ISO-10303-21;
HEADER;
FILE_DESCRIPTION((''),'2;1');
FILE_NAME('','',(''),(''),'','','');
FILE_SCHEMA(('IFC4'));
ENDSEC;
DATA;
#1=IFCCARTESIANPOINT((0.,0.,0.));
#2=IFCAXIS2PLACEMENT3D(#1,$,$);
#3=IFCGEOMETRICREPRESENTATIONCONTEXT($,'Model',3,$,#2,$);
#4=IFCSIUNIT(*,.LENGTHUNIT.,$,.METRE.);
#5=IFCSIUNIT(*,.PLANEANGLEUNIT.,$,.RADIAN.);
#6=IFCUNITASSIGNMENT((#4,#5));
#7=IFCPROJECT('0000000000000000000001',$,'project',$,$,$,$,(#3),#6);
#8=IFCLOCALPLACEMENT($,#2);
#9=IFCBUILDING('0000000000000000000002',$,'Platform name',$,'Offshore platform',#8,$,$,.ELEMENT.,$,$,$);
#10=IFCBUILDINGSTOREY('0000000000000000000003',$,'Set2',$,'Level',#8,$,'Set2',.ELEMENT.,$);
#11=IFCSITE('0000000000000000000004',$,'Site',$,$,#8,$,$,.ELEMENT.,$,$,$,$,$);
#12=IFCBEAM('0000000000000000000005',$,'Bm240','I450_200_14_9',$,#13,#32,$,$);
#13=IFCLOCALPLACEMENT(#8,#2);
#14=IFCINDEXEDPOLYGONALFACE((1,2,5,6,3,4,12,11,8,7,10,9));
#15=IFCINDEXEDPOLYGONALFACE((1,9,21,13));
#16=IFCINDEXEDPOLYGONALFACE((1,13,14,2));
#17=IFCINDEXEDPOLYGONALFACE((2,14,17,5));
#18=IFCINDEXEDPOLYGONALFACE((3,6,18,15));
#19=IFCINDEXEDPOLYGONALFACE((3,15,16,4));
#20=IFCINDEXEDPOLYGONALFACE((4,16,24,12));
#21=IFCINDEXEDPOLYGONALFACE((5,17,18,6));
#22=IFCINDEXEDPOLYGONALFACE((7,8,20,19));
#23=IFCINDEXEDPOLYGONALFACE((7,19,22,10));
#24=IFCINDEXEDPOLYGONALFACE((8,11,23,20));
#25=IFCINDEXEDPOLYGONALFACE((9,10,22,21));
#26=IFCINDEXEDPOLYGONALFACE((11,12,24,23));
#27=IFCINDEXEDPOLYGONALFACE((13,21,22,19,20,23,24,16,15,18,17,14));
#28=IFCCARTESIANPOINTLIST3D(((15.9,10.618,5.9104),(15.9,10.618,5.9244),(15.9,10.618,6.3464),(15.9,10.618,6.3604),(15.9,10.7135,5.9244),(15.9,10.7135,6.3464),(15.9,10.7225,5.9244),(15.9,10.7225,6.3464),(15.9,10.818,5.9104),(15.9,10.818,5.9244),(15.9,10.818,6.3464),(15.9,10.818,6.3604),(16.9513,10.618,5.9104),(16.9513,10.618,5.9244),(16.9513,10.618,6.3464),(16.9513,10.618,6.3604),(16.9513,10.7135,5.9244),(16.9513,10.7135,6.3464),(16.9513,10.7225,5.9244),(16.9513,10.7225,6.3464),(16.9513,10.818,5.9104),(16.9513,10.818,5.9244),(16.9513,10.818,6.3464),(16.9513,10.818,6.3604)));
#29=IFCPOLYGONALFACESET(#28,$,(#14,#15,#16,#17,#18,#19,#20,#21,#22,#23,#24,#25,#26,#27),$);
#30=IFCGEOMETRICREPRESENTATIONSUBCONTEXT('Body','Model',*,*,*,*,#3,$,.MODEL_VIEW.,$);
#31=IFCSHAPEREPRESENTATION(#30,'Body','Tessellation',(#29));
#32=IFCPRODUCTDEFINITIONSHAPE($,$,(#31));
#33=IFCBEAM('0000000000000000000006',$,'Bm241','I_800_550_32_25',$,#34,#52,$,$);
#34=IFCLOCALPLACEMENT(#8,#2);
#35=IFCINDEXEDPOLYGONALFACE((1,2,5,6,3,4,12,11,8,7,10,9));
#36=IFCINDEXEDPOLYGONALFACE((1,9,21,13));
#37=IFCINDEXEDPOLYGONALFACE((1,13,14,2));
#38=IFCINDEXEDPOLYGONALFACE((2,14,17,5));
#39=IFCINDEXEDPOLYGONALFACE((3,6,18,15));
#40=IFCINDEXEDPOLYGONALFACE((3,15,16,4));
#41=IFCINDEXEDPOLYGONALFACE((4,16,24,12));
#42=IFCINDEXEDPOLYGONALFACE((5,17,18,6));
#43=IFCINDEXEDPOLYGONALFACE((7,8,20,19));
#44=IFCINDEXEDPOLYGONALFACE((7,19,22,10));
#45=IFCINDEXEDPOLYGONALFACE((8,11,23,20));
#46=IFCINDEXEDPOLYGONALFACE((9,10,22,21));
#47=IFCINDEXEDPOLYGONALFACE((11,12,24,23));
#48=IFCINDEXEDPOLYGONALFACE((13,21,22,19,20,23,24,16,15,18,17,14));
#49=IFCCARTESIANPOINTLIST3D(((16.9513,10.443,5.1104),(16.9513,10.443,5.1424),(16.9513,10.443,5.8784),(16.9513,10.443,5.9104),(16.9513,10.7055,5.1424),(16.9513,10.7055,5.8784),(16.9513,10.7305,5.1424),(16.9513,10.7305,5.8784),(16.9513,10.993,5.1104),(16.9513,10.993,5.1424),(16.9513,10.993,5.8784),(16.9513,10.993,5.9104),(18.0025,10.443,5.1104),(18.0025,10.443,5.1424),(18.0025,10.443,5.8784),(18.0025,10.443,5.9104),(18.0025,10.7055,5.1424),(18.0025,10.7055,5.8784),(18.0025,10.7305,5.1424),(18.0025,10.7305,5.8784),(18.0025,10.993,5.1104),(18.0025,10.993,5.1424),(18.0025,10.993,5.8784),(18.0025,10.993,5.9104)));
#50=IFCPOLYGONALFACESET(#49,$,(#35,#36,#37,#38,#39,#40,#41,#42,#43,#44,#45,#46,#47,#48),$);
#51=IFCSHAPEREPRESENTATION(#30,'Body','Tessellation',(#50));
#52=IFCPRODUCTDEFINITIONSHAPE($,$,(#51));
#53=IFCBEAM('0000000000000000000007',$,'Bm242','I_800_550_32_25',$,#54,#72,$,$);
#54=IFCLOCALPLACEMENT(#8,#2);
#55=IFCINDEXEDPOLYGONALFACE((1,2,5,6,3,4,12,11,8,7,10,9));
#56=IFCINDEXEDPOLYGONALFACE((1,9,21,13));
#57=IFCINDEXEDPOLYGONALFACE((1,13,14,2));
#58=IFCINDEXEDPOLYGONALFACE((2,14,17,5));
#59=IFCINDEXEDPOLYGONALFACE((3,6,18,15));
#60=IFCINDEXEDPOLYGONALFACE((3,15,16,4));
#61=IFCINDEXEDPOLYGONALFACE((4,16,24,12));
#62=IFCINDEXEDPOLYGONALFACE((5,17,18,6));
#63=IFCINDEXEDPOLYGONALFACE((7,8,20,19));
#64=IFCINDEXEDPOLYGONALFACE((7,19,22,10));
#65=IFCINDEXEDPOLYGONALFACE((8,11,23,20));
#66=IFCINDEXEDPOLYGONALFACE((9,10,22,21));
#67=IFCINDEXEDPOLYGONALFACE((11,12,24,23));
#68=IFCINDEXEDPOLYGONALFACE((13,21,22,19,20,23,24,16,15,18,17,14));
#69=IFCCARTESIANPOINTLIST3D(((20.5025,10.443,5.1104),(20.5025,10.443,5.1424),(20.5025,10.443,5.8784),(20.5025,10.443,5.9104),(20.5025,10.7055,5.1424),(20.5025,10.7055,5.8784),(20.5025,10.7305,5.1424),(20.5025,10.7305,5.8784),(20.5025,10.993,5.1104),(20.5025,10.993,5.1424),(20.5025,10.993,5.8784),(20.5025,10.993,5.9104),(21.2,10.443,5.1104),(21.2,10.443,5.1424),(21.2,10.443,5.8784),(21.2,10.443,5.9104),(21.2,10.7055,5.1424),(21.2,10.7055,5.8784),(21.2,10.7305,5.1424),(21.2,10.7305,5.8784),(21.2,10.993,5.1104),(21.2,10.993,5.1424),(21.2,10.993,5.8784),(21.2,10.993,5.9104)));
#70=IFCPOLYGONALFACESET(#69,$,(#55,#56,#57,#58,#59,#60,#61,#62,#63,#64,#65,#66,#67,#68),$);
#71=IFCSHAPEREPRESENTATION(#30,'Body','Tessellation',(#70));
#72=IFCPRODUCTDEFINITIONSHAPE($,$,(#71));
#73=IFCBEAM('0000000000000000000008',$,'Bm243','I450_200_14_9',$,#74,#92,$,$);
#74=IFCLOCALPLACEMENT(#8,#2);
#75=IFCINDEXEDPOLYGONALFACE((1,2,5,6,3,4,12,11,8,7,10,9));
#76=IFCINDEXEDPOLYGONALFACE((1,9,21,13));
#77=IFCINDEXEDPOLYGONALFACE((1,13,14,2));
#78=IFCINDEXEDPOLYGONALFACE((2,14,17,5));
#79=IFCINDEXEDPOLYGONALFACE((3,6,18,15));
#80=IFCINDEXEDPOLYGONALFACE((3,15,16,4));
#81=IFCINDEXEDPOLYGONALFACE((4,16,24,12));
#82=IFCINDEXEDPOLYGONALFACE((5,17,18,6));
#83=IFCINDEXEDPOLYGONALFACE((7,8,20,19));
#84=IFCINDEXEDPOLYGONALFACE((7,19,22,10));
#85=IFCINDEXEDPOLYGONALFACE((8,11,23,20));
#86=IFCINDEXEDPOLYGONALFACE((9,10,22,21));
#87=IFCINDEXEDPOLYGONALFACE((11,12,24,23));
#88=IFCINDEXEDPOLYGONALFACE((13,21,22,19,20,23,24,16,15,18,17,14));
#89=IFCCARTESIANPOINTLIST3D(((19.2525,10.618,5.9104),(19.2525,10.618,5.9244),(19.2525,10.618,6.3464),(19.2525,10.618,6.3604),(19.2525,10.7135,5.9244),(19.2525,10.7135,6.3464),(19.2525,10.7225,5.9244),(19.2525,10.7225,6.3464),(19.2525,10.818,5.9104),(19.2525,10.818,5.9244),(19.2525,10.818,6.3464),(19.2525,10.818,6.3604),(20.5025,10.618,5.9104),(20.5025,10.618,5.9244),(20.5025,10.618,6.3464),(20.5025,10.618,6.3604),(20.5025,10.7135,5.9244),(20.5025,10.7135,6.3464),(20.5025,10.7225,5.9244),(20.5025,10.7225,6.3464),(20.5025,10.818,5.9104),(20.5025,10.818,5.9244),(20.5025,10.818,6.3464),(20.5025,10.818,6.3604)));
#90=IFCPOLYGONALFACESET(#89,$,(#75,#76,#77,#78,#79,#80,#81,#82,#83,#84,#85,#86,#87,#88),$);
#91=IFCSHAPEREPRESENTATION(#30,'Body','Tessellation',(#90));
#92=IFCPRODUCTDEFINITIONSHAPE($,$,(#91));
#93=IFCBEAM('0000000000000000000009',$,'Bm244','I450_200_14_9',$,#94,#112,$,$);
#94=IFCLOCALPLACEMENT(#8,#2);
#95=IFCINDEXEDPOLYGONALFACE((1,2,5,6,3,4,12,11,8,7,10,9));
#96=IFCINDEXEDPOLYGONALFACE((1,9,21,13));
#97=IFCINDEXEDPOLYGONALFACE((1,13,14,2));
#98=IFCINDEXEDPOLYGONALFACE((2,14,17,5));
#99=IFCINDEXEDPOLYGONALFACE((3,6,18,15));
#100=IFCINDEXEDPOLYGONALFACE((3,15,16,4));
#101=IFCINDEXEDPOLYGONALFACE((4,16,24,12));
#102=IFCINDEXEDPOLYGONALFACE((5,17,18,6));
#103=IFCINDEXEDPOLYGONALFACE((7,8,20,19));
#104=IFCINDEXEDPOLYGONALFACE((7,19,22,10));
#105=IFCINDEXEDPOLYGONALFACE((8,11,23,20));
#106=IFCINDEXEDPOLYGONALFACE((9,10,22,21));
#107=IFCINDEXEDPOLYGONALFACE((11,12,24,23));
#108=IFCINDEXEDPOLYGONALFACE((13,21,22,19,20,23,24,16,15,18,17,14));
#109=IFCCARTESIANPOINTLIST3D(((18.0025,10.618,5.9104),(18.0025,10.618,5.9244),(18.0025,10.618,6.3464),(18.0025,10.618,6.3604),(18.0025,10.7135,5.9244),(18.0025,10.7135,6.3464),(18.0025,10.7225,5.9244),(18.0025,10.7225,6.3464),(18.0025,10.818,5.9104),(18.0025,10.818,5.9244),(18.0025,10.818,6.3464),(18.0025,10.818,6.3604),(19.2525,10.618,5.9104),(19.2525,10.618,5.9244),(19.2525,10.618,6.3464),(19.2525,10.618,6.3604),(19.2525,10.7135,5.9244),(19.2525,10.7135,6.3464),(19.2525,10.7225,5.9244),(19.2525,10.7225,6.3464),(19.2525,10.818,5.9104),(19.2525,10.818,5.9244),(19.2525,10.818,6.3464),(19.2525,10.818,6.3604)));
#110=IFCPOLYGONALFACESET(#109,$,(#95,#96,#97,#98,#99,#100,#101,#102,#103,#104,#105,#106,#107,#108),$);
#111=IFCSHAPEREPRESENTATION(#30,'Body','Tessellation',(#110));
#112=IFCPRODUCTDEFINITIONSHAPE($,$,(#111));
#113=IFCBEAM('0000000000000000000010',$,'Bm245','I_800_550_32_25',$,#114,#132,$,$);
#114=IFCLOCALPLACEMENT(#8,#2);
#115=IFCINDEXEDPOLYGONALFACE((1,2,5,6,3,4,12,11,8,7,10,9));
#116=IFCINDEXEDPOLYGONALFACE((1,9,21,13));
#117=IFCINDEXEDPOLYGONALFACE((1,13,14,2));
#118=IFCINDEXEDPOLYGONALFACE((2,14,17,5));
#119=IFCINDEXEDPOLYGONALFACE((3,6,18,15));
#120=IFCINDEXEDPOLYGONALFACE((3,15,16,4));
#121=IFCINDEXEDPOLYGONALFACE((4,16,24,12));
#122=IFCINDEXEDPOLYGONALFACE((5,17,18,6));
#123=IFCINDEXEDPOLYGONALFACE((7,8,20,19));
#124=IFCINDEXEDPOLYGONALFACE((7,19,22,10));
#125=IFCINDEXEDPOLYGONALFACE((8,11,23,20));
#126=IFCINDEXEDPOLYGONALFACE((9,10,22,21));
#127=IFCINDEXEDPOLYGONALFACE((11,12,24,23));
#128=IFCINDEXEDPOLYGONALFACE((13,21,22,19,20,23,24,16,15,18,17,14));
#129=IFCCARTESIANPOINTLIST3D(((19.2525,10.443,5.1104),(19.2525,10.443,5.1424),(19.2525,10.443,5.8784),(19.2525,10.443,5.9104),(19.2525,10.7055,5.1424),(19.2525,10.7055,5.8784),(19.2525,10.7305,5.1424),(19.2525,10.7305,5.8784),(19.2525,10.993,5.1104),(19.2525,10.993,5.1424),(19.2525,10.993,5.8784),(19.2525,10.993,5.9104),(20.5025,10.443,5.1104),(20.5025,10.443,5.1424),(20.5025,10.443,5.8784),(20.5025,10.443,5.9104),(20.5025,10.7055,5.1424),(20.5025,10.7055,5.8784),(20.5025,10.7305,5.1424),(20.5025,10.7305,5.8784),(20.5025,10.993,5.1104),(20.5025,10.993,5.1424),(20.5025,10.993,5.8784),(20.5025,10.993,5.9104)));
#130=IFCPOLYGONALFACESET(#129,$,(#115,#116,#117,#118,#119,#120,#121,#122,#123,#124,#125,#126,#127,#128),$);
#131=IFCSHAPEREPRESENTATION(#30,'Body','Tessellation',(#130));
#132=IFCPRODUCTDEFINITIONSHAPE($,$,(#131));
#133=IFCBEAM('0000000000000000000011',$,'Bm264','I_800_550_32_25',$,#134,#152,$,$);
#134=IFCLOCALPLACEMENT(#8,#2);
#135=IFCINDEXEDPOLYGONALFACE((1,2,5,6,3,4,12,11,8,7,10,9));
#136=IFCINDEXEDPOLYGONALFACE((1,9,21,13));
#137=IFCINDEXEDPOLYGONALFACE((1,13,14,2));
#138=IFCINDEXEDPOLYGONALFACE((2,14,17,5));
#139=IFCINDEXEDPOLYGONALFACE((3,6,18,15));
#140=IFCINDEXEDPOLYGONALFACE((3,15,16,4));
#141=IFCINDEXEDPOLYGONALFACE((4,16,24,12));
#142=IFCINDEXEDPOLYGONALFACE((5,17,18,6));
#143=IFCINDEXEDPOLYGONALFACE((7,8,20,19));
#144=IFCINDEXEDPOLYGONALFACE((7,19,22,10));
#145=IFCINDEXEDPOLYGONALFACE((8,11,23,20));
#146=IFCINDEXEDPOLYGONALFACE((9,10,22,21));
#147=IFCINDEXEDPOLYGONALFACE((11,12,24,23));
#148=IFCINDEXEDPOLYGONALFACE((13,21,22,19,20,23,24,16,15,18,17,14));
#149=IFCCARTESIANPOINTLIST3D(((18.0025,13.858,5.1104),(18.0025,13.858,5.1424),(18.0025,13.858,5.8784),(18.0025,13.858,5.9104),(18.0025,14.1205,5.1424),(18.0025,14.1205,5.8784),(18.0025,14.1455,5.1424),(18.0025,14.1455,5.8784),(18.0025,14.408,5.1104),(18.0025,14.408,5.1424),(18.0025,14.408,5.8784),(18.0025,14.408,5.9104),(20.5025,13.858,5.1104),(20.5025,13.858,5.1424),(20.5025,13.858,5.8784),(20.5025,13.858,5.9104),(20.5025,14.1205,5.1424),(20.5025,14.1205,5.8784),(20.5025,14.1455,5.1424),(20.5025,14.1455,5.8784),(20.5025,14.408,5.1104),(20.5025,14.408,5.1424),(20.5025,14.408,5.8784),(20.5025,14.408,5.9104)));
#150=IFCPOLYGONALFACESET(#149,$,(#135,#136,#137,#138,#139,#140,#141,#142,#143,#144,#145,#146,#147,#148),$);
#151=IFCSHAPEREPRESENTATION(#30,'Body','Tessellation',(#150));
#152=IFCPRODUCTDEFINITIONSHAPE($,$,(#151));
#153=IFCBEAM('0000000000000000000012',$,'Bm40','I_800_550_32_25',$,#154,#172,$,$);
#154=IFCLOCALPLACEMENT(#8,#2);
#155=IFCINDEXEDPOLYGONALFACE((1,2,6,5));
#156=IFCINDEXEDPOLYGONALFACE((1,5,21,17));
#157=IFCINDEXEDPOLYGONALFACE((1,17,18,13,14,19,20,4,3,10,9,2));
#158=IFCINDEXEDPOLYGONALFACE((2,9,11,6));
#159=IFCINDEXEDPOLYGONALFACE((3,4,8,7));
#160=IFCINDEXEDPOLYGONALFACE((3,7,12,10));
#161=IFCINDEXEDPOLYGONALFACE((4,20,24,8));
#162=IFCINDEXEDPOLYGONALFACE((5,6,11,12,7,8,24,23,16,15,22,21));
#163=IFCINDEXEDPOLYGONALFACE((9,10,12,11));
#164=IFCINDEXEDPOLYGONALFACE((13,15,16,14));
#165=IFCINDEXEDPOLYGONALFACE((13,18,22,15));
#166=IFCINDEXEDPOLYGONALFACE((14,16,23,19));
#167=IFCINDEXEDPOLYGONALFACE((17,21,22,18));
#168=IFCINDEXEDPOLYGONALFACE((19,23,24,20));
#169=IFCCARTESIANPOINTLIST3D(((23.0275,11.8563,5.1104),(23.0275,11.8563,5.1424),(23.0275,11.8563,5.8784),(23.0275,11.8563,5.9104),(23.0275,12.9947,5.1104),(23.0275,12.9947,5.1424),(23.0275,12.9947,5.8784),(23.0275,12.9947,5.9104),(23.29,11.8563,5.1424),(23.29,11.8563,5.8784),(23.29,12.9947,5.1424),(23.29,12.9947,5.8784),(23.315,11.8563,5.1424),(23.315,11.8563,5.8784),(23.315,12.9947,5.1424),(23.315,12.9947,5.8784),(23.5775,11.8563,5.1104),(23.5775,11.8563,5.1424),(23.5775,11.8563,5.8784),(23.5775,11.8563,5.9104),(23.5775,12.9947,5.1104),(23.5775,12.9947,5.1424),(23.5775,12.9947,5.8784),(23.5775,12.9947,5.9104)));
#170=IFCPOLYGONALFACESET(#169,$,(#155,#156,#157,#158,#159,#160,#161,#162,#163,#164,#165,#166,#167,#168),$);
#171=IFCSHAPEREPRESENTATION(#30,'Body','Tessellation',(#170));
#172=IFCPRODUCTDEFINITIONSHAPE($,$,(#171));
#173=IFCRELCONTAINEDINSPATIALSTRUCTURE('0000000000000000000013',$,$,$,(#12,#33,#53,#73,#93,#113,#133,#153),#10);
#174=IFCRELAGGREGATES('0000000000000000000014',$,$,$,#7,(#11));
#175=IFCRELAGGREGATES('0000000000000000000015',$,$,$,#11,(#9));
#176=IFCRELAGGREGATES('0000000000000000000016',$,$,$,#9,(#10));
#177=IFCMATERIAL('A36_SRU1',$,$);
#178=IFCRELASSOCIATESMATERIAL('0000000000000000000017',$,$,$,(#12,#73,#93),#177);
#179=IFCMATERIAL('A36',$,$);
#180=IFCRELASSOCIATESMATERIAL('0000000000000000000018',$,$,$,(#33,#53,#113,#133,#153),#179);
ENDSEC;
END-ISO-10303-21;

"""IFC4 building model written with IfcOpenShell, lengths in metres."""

from ifc_helpers import new_model, si_unit, frame, origin, origin_2d, place, context, subcontext, project, spatial, i_section, extrude, source, transform, mapped, material, element, save


model = new_model("IFC4")

# Units and contexts
model_context = context("Model", 3, world=origin())
body_context = subcontext(model_context, "Body", "Model", "MODEL_VIEW")
ifc_project = project(units=[si_unit("LENGTHUNIT", "METRE"), si_unit("PLANEANGLEUNIT", "RADIAN")], contexts=[model_context])

# Site, building, storey
placement_1 = place(None, origin())
site = spatial("IfcSite", under=ifc_project, at=placement_1, Name="Site", CompositionType="ELEMENT")
building = spatial("IfcBuilding", under=site, at=placement_1, Name="Platform name", ObjectType="Offshore platform", CompositionType="ELEMENT")
storey = spatial("IfcBuildingStorey", under=building, at=placement_1, Name="Set2", ObjectType="Level", LongName="Set2", CompositionType="ELEMENT")

# Beams
ifc_material_1 = material(Name="A36_SRU1")
ifc_material_2 = material(Name="A36")
shared_shape_1 = source(origin(), body_context, "Body", "SweptSolid", [
    extrude(i_section(OverallWidth=0.2, OverallDepth=0.45, WebThickness=0.009, FlangeThickness=0.014, FilletRadius=0.0, at=origin_2d()), frame((0.0, 0.0, 0.0), z_axis=(-1.0, 0.0, 0.0), x_axis=(0.0, -1.0, 0.0)), (0.0, 0.0, 1.0), 1.0513),
])
placement_2 = place(None, origin())
placement_3 = place(placement_2, origin())
placement_4 = place(placement_3, origin())
beam_1_placement = place(placement_4, frame((16.9513, 10.718, 6.1354)))
element("IfcBeam", 1, at=beam_1_placement, inside=storey, material=ifc_material_1, Name="Bm240", Description="I450_200_14_9", context=body_context, shape_type="MappedRepresentation", body=[
    mapped(shared_shape_1, transform((0.0, 0.0, 0.0), scale=1.0)),
])
shared_shape_2 = source(origin(), body_context, "Body", "SweptSolid", [
    extrude(i_section(OverallWidth=0.55, OverallDepth=0.8, WebThickness=0.025, FlangeThickness=0.032, FilletRadius=0.0, at=origin_2d()), frame((0.0, 0.0, 0.0), z_axis=(1.0, 0.0, 0.0), x_axis=(0.0, 1.0, 0.0)), (0.0, 0.0, 1.0), 1.0513),
])
placement_5 = place(None, origin())
placement_6 = place(placement_5, origin())
placement_7 = place(placement_6, origin())
beam_2_placement = place(placement_7, frame((16.9513, 10.718, 5.5104)))
element("IfcBeam", 2, at=beam_2_placement, inside=storey, material=ifc_material_2, Name="Bm241", Description="I_800_550_32_25", context=body_context, shape_type="MappedRepresentation", body=[
    mapped(shared_shape_2, transform((0.0, 0.0, 0.0), scale=1.0)),
])
shared_shape_3 = source(origin(), body_context, "Body", "SweptSolid", [
    extrude(i_section(OverallWidth=0.55, OverallDepth=0.8, WebThickness=0.025, FlangeThickness=0.032, FilletRadius=0.0, at=origin_2d()), frame((0.0, 0.0, 0.0), z_axis=(1.0, 0.0, 0.0), x_axis=(0.0, 1.0, 0.0)), (0.0, 0.0, 1.0), 0.6975),
])
placement_8 = place(None, origin())
placement_9 = place(placement_8, origin())
placement_10 = place(placement_9, origin())
beam_3_placement = place(placement_10, frame((20.5025, 10.718, 5.5104)))
element("IfcBeam", 3, at=beam_3_placement, inside=storey, material=ifc_material_2, Name="Bm242", Description="I_800_550_32_25", context=body_context, shape_type="MappedRepresentation", body=[
    mapped(shared_shape_3, transform((0.0, 0.0, 0.0), scale=1.0)),
])
shared_shape_4 = source(origin(), body_context, "Body", "SweptSolid", [
    extrude(i_section(OverallWidth=0.2, OverallDepth=0.45, WebThickness=0.009, FlangeThickness=0.014, FilletRadius=0.0, at=origin_2d()), frame((0.0, 0.0, 0.0), z_axis=(-1.0, 0.0, 0.0), x_axis=(0.0, -1.0, 0.0)), (0.0, 0.0, 1.0), 1.25),
])
placement_11 = place(None, origin())
placement_12 = place(placement_11, origin())
placement_13 = place(placement_12, origin())
beam_4_placement = place(placement_13, frame((20.5025, 10.718, 6.1354)))
element("IfcBeam", 4, at=beam_4_placement, inside=storey, material=ifc_material_1, Name="Bm243", Description="I450_200_14_9", context=body_context, shape_type="MappedRepresentation", body=[
    mapped(shared_shape_4, transform((0.0, 0.0, 0.0), scale=1.0)),
])
shared_shape_5 = source(origin(), body_context, "Body", "SweptSolid", [
    extrude(i_section(OverallWidth=0.2, OverallDepth=0.45, WebThickness=0.009, FlangeThickness=0.014, FilletRadius=0.0, at=origin_2d()), frame((0.0, 0.0, 0.0), z_axis=(-1.0, 0.0, 0.0), x_axis=(0.0, -1.0, 0.0)), (0.0, 0.0, 1.0), 1.25),
])
placement_14 = place(None, origin())
placement_15 = place(placement_14, origin())
placement_16 = place(placement_15, origin())
beam_5_placement = place(placement_16, frame((19.2525, 10.718, 6.1354)))
element("IfcBeam", 5, at=beam_5_placement, inside=storey, material=ifc_material_1, Name="Bm244", Description="I450_200_14_9", context=body_context, shape_type="MappedRepresentation", body=[
    mapped(shared_shape_5, transform((0.0, 0.0, 0.0), scale=1.0)),
])
shared_shape_6 = source(origin(), body_context, "Body", "SweptSolid", [
    extrude(i_section(OverallWidth=0.55, OverallDepth=0.8, WebThickness=0.025, FlangeThickness=0.032, FilletRadius=0.0, at=origin_2d()), frame((0.0, 0.0, 0.0), z_axis=(1.0, 0.0, 0.0), x_axis=(0.0, 1.0, 0.0)), (0.0, 0.0, 1.0), 1.25),
])
placement_17 = place(None, origin())
placement_18 = place(placement_17, origin())
placement_19 = place(placement_18, origin())
beam_6_placement = place(placement_19, frame((19.2525, 10.718, 5.5104)))
element("IfcBeam", 6, at=beam_6_placement, inside=storey, material=ifc_material_2, Name="Bm245", Description="I_800_550_32_25", context=body_context, shape_type="MappedRepresentation", body=[
    mapped(shared_shape_6, transform((0.0, 0.0, 0.0), scale=1.0)),
])
shared_shape_7 = source(origin(), body_context, "Body", "SweptSolid", [
    extrude(i_section(OverallWidth=0.55, OverallDepth=0.8, WebThickness=0.025, FlangeThickness=0.032, FilletRadius=0.0, at=origin_2d()), frame((0.0, 0.0, 0.0), z_axis=(1.0, 0.0, 0.0), x_axis=(0.0, 1.0, 0.0)), (0.0, 0.0, 1.0), 2.5),
])
placement_20 = place(None, origin())
placement_21 = place(placement_20, origin())
placement_22 = place(placement_21, origin())
beam_7_placement = place(placement_22, frame((18.0025, 14.133, 5.5104)))
element("IfcBeam", 7, at=beam_7_placement, inside=storey, material=ifc_material_2, Name="Bm264", Description="I_800_550_32_25", context=body_context, shape_type="MappedRepresentation", body=[
    mapped(shared_shape_7, transform((0.0, 0.0, 0.0), scale=1.0)),
])
shared_shape_8 = source(origin(), body_context, "Body", "SweptSolid", [
    extrude(i_section(OverallWidth=0.55, OverallDepth=0.8, WebThickness=0.025, FlangeThickness=0.032, FilletRadius=0.0, at=origin_2d()), frame((0.0, 0.0, 0.0), z_axis=(0.0, -1.0, 0.0), x_axis=(1.0, 0.0, 0.0)), (0.0, 0.0, 1.0), 1.1383),
])
placement_23 = place(None, origin())
placement_24 = place(placement_23, origin())
placement_25 = place(placement_24, origin())
beam_8_placement = place(placement_25, frame((23.3025, 12.9947, 5.5104)))
element("IfcBeam", 8, at=beam_8_placement, inside=storey, material=ifc_material_2, Name="Bm40", Description="I_800_550_32_25", context=body_context, shape_type="MappedRepresentation", body=[
    mapped(shared_shape_8, transform((0.0, 0.0, 0.0), scale=1.0)),
])

save(model, "model.ifc")
